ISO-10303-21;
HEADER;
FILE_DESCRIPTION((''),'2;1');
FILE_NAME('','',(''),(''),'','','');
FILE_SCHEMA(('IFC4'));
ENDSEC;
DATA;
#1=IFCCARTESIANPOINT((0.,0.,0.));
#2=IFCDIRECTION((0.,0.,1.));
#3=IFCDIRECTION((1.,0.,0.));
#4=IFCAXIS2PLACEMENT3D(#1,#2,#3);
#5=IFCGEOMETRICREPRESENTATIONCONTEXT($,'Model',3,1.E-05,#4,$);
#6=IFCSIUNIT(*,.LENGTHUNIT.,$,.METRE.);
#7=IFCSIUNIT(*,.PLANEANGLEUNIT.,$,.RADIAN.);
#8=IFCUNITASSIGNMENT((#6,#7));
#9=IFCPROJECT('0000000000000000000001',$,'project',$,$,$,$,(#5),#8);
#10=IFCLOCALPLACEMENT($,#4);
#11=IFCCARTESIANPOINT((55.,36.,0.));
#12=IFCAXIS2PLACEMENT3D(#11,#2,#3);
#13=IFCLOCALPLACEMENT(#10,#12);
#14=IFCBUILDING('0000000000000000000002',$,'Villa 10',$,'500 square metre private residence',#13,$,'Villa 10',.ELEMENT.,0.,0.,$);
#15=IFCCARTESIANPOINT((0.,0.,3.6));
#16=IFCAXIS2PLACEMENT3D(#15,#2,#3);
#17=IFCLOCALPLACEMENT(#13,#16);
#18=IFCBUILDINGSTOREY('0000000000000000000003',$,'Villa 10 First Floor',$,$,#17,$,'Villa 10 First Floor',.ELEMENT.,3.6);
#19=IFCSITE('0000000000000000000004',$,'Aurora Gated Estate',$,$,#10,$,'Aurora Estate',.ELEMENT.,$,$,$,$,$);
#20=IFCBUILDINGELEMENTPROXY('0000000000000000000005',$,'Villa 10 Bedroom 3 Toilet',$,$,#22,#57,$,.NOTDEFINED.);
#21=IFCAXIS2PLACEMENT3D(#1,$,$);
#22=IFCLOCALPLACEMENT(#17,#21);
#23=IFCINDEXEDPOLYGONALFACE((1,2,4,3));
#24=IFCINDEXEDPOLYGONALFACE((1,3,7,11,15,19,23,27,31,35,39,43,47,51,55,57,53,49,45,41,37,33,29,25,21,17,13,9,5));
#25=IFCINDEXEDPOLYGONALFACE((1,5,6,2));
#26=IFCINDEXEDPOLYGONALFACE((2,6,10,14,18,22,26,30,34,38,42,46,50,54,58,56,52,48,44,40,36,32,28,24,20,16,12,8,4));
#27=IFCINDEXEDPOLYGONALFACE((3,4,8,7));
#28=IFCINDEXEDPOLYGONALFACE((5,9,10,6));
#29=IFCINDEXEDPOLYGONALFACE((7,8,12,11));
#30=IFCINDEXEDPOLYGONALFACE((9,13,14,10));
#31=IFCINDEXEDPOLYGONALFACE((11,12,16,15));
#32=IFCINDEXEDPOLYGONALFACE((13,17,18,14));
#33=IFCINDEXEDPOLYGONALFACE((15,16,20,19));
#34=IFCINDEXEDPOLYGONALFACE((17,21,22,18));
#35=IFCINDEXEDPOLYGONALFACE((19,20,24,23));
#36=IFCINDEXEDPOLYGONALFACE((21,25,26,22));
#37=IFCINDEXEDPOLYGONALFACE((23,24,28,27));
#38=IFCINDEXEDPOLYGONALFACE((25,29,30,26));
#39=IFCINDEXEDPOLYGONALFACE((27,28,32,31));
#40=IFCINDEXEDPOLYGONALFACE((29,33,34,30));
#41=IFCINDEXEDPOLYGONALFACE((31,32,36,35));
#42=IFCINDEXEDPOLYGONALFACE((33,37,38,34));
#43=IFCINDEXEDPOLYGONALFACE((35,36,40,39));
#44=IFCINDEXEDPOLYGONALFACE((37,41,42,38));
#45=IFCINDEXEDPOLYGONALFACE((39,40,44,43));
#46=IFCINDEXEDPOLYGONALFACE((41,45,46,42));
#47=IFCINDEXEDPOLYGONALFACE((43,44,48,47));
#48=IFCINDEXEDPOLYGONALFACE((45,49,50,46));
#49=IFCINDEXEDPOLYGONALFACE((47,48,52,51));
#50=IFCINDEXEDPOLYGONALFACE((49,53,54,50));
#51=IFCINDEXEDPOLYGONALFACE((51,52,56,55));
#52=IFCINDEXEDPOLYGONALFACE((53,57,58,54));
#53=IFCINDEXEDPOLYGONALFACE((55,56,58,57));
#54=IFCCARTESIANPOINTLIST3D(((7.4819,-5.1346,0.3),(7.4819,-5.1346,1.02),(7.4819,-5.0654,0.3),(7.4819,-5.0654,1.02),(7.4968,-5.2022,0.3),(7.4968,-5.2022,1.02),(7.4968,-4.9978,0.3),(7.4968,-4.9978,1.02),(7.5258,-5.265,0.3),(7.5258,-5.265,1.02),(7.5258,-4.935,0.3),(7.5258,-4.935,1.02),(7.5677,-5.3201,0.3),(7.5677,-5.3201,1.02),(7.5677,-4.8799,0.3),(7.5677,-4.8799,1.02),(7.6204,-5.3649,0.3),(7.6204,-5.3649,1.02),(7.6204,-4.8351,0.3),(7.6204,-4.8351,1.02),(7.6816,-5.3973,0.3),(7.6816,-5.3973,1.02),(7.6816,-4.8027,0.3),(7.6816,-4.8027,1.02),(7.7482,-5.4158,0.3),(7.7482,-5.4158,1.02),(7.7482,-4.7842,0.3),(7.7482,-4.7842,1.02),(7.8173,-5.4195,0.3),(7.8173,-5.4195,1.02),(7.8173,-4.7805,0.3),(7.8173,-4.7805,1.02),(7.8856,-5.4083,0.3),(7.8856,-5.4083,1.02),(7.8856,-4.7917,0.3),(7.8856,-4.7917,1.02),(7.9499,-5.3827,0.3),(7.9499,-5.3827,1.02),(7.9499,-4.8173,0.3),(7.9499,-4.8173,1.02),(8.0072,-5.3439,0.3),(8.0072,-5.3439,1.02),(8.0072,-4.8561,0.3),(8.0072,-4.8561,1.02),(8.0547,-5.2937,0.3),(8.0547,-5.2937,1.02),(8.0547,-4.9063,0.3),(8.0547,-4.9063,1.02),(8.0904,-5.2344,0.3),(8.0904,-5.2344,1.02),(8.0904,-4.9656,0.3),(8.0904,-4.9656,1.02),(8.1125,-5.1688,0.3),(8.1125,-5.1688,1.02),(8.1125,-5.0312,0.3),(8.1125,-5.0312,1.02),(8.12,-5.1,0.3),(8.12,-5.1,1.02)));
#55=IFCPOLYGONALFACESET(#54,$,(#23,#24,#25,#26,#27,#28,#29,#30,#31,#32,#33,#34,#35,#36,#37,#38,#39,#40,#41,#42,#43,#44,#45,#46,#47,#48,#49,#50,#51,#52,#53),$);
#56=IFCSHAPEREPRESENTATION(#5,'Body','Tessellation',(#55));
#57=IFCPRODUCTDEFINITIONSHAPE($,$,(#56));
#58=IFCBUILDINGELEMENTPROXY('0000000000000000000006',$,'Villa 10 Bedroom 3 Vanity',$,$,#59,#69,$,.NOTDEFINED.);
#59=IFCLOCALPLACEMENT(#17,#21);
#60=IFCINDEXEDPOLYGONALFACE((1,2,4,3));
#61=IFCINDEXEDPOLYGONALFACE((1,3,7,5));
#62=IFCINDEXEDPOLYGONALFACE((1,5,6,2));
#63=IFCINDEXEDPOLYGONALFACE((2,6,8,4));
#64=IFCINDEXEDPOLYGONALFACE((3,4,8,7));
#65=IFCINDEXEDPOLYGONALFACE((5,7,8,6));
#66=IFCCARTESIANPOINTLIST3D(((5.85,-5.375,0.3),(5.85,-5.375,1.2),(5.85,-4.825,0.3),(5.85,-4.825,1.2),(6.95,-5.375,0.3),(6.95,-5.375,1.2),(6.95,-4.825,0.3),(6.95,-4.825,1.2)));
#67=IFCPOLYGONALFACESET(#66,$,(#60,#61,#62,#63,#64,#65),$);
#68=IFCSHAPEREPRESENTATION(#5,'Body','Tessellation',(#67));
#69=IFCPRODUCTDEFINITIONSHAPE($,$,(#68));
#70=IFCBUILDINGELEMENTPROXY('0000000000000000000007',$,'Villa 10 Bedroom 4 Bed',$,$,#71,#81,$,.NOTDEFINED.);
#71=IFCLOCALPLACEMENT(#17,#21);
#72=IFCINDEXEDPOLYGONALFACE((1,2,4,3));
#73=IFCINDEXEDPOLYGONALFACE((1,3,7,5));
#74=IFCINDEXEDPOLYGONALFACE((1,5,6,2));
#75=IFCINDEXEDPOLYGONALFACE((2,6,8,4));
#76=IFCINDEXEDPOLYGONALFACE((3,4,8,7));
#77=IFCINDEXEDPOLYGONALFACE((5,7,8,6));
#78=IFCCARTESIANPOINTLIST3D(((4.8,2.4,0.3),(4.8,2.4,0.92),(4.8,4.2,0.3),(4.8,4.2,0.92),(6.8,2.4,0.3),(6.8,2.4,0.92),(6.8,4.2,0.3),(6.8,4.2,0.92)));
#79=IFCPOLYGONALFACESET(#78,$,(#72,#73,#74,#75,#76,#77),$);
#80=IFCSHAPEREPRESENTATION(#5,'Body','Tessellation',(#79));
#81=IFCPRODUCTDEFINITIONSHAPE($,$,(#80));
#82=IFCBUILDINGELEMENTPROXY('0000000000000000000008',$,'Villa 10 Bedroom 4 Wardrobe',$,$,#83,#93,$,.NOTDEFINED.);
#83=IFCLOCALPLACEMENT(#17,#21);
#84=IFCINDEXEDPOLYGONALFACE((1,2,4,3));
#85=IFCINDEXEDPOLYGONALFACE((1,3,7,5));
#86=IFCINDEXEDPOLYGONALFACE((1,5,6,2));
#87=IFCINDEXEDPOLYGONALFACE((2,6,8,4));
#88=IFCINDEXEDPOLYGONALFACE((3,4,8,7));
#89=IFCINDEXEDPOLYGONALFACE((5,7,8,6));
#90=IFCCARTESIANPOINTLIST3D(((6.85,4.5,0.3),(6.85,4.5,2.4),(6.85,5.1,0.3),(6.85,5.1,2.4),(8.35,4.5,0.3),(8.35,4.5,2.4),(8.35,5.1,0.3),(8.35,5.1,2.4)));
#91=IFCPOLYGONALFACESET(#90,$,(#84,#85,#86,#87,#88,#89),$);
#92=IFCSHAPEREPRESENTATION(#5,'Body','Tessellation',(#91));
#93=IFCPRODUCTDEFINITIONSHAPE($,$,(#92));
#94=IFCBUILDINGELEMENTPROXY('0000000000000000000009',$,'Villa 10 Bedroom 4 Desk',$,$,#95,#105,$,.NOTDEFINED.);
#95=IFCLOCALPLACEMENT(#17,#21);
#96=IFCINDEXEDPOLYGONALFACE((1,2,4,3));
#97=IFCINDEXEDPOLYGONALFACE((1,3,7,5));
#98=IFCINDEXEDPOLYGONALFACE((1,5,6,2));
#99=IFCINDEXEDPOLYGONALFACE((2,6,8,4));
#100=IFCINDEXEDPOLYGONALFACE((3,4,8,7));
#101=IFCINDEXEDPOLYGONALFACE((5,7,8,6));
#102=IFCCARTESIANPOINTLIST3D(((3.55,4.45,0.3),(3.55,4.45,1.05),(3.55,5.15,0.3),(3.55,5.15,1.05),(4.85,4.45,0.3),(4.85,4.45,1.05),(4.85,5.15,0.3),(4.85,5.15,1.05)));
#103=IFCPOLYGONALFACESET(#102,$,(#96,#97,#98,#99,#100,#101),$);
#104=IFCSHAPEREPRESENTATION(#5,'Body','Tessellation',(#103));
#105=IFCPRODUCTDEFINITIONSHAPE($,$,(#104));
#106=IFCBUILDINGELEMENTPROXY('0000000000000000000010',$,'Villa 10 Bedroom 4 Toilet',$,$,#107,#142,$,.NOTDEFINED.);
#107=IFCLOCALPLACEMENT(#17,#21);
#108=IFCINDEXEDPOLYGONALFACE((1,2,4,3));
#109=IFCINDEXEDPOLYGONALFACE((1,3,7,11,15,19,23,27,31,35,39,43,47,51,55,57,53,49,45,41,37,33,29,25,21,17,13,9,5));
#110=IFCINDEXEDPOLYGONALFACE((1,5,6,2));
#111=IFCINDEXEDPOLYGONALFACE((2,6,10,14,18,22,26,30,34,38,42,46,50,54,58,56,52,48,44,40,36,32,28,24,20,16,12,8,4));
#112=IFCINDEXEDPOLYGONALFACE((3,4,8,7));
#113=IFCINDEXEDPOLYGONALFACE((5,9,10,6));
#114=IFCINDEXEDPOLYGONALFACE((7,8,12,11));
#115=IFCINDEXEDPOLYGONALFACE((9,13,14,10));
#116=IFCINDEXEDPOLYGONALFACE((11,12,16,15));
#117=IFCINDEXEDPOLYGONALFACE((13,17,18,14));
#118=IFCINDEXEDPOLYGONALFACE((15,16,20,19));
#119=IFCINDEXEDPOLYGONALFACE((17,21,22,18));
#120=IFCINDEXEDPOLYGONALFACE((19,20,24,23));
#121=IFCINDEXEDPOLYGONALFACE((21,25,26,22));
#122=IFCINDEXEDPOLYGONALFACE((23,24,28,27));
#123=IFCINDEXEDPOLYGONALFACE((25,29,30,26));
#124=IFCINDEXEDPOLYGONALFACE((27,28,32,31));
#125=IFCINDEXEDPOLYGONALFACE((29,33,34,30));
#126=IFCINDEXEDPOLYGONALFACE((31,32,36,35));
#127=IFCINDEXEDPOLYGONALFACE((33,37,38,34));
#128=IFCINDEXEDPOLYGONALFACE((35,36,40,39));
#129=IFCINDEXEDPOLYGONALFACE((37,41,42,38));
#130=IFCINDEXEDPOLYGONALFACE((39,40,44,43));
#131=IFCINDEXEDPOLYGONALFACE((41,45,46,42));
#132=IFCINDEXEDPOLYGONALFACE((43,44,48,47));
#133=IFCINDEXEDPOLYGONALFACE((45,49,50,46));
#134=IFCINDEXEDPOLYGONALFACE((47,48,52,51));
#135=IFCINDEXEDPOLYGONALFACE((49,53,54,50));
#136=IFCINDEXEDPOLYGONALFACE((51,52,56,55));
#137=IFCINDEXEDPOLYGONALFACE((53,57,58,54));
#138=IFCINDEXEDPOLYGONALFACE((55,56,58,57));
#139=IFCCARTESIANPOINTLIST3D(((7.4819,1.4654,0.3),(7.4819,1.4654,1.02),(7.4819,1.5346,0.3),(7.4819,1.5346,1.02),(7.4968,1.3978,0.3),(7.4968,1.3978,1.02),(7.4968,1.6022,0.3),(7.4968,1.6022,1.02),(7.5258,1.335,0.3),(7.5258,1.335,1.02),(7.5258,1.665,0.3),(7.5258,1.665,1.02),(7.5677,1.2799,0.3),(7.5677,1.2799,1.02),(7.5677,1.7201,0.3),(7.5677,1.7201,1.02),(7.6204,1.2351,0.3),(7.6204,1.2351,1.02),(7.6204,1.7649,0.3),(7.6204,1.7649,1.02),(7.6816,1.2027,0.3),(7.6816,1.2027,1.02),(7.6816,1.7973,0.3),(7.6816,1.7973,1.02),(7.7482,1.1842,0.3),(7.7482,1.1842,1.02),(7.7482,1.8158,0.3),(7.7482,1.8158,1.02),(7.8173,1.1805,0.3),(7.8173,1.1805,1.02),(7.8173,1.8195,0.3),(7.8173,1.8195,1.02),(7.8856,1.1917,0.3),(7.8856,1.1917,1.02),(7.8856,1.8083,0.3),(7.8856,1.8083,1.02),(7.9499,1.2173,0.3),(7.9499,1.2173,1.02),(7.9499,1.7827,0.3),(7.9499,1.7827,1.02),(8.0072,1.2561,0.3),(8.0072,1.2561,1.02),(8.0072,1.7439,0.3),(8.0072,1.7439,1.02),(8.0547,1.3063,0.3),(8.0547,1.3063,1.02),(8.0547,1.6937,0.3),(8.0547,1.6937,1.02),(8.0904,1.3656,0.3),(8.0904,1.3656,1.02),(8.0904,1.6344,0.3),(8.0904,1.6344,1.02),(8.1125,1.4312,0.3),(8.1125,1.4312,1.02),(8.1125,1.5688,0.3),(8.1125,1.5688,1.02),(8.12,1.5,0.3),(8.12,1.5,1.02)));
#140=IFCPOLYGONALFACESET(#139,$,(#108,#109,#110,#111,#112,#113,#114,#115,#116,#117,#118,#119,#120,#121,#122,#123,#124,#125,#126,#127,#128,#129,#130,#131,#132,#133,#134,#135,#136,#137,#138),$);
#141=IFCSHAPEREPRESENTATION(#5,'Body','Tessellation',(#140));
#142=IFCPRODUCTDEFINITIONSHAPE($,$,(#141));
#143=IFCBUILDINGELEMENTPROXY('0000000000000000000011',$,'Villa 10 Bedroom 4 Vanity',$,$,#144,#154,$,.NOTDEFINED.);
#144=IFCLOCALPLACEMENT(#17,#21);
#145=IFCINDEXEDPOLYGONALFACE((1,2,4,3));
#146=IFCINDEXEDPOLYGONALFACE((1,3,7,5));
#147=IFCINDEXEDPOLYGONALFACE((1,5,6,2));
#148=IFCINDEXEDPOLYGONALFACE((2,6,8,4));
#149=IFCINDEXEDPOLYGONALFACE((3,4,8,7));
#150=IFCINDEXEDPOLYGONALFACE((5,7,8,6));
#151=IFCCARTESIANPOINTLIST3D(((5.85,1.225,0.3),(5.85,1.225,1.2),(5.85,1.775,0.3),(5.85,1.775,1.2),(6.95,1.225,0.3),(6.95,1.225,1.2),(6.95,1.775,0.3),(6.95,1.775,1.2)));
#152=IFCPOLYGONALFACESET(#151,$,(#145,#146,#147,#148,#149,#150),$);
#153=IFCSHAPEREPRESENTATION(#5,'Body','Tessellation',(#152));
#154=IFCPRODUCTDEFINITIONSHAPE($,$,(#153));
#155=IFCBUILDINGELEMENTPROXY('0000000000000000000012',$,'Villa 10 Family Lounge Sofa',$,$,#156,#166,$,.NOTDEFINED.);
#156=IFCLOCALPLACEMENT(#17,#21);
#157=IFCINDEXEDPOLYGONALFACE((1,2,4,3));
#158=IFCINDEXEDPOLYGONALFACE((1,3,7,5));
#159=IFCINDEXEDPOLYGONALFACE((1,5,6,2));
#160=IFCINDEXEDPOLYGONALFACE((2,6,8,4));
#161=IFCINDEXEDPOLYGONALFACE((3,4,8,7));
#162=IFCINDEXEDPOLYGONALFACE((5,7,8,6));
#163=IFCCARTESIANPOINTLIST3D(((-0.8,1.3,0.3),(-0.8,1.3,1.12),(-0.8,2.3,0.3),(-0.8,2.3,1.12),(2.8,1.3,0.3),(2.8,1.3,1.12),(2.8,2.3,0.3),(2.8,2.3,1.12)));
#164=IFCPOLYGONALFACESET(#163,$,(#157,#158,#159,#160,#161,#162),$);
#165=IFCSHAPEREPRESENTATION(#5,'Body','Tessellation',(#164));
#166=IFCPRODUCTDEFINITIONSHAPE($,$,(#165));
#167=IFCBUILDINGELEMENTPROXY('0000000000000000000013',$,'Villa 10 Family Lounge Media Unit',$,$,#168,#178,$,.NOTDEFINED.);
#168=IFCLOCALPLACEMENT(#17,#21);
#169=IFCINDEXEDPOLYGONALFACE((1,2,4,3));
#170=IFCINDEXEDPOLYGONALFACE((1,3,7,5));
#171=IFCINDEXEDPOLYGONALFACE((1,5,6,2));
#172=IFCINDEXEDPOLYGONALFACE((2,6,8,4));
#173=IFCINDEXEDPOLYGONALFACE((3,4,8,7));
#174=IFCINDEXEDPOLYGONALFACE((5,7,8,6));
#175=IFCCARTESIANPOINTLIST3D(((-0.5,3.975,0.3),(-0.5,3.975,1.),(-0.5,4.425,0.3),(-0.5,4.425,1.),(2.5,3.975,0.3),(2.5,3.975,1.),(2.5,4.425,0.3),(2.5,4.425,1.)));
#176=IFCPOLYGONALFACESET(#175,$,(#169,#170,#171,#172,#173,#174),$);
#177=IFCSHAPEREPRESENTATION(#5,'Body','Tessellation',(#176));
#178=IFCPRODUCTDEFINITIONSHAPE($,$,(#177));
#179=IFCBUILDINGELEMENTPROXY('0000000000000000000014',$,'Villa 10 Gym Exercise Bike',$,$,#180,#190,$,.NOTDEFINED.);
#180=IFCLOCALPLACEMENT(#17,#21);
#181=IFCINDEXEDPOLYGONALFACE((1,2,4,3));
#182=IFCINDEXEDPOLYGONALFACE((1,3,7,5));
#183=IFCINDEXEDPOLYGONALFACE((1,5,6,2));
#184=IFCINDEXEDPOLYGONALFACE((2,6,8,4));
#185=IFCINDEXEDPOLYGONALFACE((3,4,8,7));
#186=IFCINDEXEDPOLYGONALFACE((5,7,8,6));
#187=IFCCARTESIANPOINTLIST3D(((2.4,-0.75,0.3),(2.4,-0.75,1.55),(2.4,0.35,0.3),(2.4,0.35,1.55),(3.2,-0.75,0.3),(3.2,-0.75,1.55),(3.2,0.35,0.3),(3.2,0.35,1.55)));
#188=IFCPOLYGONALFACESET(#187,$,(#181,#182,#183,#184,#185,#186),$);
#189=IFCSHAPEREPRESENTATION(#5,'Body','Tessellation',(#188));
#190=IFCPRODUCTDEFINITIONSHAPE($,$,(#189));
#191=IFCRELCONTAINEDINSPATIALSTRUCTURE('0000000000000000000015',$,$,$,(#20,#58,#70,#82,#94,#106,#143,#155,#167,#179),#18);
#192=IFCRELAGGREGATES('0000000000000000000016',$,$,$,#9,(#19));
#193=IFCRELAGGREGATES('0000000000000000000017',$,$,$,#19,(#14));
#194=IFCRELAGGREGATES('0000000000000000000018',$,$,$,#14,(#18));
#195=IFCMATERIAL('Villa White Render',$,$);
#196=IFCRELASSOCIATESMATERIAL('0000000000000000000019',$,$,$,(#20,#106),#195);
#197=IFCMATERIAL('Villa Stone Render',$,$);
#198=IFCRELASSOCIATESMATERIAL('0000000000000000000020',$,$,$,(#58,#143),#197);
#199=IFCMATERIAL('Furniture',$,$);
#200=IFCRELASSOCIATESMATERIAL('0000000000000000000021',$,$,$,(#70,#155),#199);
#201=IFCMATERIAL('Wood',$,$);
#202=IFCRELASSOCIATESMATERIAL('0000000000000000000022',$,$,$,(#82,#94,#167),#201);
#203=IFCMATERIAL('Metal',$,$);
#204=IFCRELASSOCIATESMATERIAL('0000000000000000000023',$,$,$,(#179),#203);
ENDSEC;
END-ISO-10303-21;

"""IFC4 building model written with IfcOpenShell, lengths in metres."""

from ifc_helpers import new_model, si_unit, frame, origin_with_axes, origin_2d_with_axis, place, context, project, spatial, rectangle, circle, extrude, material, element, save


model = new_model("IFC4")

# Units and contexts
model_context = context("Model", 3, precision=1e-05, world=origin_with_axes())
ifc_project = project(units=[si_unit("LENGTHUNIT", "METRE"), si_unit("PLANEANGLEUNIT", "RADIAN")], contexts=[model_context])

# Site, building, storey
site_placement = place(None, origin_with_axes())
site = spatial("IfcSite", under=ifc_project, at=site_placement, Name="Aurora Gated Estate", LongName="Aurora Estate", CompositionType="ELEMENT")
building_placement = place(site_placement, frame((55.0, 36.0, 0.0), z_axis=(0.0, 0.0, 1.0), x_axis=(1.0, 0.0, 0.0)))
building = spatial("IfcBuilding", under=site, at=building_placement, Name="Villa 10", ObjectType="500 square metre private residence", LongName="Villa 10", CompositionType="ELEMENT", ElevationOfRefHeight=0.0, ElevationOfTerrain=0.0)
storey_placement = place(building_placement, frame((0.0, 0.0, 3.6), z_axis=(0.0, 0.0, 1.0), x_axis=(1.0, 0.0, 0.0)))
storey = spatial("IfcBuildingStorey", under=building, at=storey_placement, Name="Villa 10 First Floor", LongName="Villa 10 First Floor", CompositionType="ELEMENT", Elevation=3.6)

# Shared definitions
ifc_material_1 = material(Name="Villa White Render")

# Building element proxies
ifc_material_2 = material(Name="Wood")
ifc_material_3 = material(Name="Villa Stone Render")
ifc_material_4 = material(Name="Furniture")
proxy_1_placement = place(storey_placement, frame((7.8, -5.1, 0.3), z_axis=(0.0, 0.0, 1.0), x_axis=(1.0, 0.0, 0.0)))
element("IfcBuildingElementProxy", 1, at=proxy_1_placement, inside=storey, material=ifc_material_1, Name="Villa 10 Bedroom 3 Toilet", PredefinedType="NOTDEFINED", context=model_context, shape_type="SweptSolid", body=[
    extrude(circle(Radius=0.32, at=origin_2d_with_axis()), origin_with_axes(), (0.0, 0.0, 1.0), 0.72),
])
proxy_2_placement = place(storey_placement, frame((6.4, -5.1, 0.3), z_axis=(0.0, 0.0, 1.0), x_axis=(1.0, 0.0, 0.0)))
element("IfcBuildingElementProxy", 2, at=proxy_2_placement, inside=storey, material=ifc_material_3, Name="Villa 10 Bedroom 3 Vanity", PredefinedType="NOTDEFINED", context=model_context, shape_type="SweptSolid", body=[
    extrude(rectangle(XDim=1.1, YDim=0.55, at=origin_2d_with_axis()), origin_with_axes(), (0.0, 0.0, 1.0), 0.9),
])
proxy_3_placement = place(storey_placement, frame((5.8, 3.3, 0.3), z_axis=(0.0, 0.0, 1.0), x_axis=(1.0, 0.0, 0.0)))
element("IfcBuildingElementProxy", 3, at=proxy_3_placement, inside=storey, material=ifc_material_4, Name="Villa 10 Bedroom 4 Bed", PredefinedType="NOTDEFINED", context=model_context, shape_type="SweptSolid", body=[
    extrude(rectangle(XDim=2.0, YDim=1.8, at=origin_2d_with_axis()), origin_with_axes(), (0.0, 0.0, 1.0), 0.62),
])
proxy_4_placement = place(storey_placement, frame((7.6, 4.8, 0.3), z_axis=(0.0, 0.0, 1.0), x_axis=(1.0, 0.0, 0.0)))
element("IfcBuildingElementProxy", 4, at=proxy_4_placement, inside=storey, material=ifc_material_2, Name="Villa 10 Bedroom 4 Wardrobe", PredefinedType="NOTDEFINED", context=model_context, shape_type="SweptSolid", body=[
    extrude(rectangle(XDim=1.5, YDim=0.6, at=origin_2d_with_axis()), origin_with_axes(), (0.0, 0.0, 1.0), 2.1),
])
proxy_5_placement = place(storey_placement, frame((4.2, 4.8, 0.3), z_axis=(0.0, 0.0, 1.0), x_axis=(1.0, 0.0, 0.0)))
element("IfcBuildingElementProxy", 5, at=proxy_5_placement, inside=storey, material=ifc_material_2, Name="Villa 10 Bedroom 4 Desk", PredefinedType="NOTDEFINED", context=model_context, shape_type="SweptSolid", body=[
    extrude(rectangle(XDim=1.3, YDim=0.7, at=origin_2d_with_axis()), origin_with_axes(), (0.0, 0.0, 1.0), 0.75),
])
proxy_6_placement = place(storey_placement, frame((7.8, 1.5, 0.3), z_axis=(0.0, 0.0, 1.0), x_axis=(1.0, 0.0, 0.0)))
element("IfcBuildingElementProxy", 6, at=proxy_6_placement, inside=storey, material=ifc_material_1, Name="Villa 10 Bedroom 4 Toilet", PredefinedType="NOTDEFINED", context=model_context, shape_type="SweptSolid", body=[
    extrude(circle(Radius=0.32, at=origin_2d_with_axis()), origin_with_axes(), (0.0, 0.0, 1.0), 0.72),
])
proxy_7_placement = place(storey_placement, frame((6.4, 1.5, 0.3), z_axis=(0.0, 0.0, 1.0), x_axis=(1.0, 0.0, 0.0)))
element("IfcBuildingElementProxy", 7, at=proxy_7_placement, inside=storey, material=ifc_material_3, Name="Villa 10 Bedroom 4 Vanity", PredefinedType="NOTDEFINED", context=model_context, shape_type="SweptSolid", body=[
    extrude(rectangle(XDim=1.1, YDim=0.55, at=origin_2d_with_axis()), origin_with_axes(), (0.0, 0.0, 1.0), 0.9),
])
proxy_8_placement = place(storey_placement, frame((1.0, 1.8, 0.3), z_axis=(0.0, 0.0, 1.0), x_axis=(1.0, 0.0, 0.0)))
element("IfcBuildingElementProxy", 8, at=proxy_8_placement, inside=storey, material=ifc_material_4, Name="Villa 10 Family Lounge Sofa", PredefinedType="NOTDEFINED", context=model_context, shape_type="SweptSolid", body=[
    extrude(rectangle(XDim=3.6, YDim=1.0, at=origin_2d_with_axis()), origin_with_axes(), (0.0, 0.0, 1.0), 0.82),
])
proxy_9_placement = place(storey_placement, frame((1.0, 4.2, 0.3), z_axis=(0.0, 0.0, 1.0), x_axis=(1.0, 0.0, 0.0)))
element("IfcBuildingElementProxy", 9, at=proxy_9_placement, inside=storey, material=ifc_material_2, Name="Villa 10 Family Lounge Media Unit", PredefinedType="NOTDEFINED", context=model_context, shape_type="SweptSolid", body=[
    extrude(rectangle(XDim=3.0, YDim=0.45, at=origin_2d_with_axis()), origin_with_axes(), (0.0, 0.0, 1.0), 0.7),
])
ifc_material_5 = material(Name="Metal")
proxy_10_placement = place(storey_placement, frame((2.8, -0.2, 0.3), z_axis=(0.0, 0.0, 1.0), x_axis=(1.0, 0.0, 0.0)))
element("IfcBuildingElementProxy", 10, at=proxy_10_placement, inside=storey, material=ifc_material_5, Name="Villa 10 Gym Exercise Bike", PredefinedType="NOTDEFINED", context=model_context, shape_type="SweptSolid", body=[
    extrude(rectangle(XDim=0.8, YDim=1.1, at=origin_2d_with_axis()), origin_with_axes(), (0.0, 0.0, 1.0), 1.25),
])

save(model, "model.ifc")
